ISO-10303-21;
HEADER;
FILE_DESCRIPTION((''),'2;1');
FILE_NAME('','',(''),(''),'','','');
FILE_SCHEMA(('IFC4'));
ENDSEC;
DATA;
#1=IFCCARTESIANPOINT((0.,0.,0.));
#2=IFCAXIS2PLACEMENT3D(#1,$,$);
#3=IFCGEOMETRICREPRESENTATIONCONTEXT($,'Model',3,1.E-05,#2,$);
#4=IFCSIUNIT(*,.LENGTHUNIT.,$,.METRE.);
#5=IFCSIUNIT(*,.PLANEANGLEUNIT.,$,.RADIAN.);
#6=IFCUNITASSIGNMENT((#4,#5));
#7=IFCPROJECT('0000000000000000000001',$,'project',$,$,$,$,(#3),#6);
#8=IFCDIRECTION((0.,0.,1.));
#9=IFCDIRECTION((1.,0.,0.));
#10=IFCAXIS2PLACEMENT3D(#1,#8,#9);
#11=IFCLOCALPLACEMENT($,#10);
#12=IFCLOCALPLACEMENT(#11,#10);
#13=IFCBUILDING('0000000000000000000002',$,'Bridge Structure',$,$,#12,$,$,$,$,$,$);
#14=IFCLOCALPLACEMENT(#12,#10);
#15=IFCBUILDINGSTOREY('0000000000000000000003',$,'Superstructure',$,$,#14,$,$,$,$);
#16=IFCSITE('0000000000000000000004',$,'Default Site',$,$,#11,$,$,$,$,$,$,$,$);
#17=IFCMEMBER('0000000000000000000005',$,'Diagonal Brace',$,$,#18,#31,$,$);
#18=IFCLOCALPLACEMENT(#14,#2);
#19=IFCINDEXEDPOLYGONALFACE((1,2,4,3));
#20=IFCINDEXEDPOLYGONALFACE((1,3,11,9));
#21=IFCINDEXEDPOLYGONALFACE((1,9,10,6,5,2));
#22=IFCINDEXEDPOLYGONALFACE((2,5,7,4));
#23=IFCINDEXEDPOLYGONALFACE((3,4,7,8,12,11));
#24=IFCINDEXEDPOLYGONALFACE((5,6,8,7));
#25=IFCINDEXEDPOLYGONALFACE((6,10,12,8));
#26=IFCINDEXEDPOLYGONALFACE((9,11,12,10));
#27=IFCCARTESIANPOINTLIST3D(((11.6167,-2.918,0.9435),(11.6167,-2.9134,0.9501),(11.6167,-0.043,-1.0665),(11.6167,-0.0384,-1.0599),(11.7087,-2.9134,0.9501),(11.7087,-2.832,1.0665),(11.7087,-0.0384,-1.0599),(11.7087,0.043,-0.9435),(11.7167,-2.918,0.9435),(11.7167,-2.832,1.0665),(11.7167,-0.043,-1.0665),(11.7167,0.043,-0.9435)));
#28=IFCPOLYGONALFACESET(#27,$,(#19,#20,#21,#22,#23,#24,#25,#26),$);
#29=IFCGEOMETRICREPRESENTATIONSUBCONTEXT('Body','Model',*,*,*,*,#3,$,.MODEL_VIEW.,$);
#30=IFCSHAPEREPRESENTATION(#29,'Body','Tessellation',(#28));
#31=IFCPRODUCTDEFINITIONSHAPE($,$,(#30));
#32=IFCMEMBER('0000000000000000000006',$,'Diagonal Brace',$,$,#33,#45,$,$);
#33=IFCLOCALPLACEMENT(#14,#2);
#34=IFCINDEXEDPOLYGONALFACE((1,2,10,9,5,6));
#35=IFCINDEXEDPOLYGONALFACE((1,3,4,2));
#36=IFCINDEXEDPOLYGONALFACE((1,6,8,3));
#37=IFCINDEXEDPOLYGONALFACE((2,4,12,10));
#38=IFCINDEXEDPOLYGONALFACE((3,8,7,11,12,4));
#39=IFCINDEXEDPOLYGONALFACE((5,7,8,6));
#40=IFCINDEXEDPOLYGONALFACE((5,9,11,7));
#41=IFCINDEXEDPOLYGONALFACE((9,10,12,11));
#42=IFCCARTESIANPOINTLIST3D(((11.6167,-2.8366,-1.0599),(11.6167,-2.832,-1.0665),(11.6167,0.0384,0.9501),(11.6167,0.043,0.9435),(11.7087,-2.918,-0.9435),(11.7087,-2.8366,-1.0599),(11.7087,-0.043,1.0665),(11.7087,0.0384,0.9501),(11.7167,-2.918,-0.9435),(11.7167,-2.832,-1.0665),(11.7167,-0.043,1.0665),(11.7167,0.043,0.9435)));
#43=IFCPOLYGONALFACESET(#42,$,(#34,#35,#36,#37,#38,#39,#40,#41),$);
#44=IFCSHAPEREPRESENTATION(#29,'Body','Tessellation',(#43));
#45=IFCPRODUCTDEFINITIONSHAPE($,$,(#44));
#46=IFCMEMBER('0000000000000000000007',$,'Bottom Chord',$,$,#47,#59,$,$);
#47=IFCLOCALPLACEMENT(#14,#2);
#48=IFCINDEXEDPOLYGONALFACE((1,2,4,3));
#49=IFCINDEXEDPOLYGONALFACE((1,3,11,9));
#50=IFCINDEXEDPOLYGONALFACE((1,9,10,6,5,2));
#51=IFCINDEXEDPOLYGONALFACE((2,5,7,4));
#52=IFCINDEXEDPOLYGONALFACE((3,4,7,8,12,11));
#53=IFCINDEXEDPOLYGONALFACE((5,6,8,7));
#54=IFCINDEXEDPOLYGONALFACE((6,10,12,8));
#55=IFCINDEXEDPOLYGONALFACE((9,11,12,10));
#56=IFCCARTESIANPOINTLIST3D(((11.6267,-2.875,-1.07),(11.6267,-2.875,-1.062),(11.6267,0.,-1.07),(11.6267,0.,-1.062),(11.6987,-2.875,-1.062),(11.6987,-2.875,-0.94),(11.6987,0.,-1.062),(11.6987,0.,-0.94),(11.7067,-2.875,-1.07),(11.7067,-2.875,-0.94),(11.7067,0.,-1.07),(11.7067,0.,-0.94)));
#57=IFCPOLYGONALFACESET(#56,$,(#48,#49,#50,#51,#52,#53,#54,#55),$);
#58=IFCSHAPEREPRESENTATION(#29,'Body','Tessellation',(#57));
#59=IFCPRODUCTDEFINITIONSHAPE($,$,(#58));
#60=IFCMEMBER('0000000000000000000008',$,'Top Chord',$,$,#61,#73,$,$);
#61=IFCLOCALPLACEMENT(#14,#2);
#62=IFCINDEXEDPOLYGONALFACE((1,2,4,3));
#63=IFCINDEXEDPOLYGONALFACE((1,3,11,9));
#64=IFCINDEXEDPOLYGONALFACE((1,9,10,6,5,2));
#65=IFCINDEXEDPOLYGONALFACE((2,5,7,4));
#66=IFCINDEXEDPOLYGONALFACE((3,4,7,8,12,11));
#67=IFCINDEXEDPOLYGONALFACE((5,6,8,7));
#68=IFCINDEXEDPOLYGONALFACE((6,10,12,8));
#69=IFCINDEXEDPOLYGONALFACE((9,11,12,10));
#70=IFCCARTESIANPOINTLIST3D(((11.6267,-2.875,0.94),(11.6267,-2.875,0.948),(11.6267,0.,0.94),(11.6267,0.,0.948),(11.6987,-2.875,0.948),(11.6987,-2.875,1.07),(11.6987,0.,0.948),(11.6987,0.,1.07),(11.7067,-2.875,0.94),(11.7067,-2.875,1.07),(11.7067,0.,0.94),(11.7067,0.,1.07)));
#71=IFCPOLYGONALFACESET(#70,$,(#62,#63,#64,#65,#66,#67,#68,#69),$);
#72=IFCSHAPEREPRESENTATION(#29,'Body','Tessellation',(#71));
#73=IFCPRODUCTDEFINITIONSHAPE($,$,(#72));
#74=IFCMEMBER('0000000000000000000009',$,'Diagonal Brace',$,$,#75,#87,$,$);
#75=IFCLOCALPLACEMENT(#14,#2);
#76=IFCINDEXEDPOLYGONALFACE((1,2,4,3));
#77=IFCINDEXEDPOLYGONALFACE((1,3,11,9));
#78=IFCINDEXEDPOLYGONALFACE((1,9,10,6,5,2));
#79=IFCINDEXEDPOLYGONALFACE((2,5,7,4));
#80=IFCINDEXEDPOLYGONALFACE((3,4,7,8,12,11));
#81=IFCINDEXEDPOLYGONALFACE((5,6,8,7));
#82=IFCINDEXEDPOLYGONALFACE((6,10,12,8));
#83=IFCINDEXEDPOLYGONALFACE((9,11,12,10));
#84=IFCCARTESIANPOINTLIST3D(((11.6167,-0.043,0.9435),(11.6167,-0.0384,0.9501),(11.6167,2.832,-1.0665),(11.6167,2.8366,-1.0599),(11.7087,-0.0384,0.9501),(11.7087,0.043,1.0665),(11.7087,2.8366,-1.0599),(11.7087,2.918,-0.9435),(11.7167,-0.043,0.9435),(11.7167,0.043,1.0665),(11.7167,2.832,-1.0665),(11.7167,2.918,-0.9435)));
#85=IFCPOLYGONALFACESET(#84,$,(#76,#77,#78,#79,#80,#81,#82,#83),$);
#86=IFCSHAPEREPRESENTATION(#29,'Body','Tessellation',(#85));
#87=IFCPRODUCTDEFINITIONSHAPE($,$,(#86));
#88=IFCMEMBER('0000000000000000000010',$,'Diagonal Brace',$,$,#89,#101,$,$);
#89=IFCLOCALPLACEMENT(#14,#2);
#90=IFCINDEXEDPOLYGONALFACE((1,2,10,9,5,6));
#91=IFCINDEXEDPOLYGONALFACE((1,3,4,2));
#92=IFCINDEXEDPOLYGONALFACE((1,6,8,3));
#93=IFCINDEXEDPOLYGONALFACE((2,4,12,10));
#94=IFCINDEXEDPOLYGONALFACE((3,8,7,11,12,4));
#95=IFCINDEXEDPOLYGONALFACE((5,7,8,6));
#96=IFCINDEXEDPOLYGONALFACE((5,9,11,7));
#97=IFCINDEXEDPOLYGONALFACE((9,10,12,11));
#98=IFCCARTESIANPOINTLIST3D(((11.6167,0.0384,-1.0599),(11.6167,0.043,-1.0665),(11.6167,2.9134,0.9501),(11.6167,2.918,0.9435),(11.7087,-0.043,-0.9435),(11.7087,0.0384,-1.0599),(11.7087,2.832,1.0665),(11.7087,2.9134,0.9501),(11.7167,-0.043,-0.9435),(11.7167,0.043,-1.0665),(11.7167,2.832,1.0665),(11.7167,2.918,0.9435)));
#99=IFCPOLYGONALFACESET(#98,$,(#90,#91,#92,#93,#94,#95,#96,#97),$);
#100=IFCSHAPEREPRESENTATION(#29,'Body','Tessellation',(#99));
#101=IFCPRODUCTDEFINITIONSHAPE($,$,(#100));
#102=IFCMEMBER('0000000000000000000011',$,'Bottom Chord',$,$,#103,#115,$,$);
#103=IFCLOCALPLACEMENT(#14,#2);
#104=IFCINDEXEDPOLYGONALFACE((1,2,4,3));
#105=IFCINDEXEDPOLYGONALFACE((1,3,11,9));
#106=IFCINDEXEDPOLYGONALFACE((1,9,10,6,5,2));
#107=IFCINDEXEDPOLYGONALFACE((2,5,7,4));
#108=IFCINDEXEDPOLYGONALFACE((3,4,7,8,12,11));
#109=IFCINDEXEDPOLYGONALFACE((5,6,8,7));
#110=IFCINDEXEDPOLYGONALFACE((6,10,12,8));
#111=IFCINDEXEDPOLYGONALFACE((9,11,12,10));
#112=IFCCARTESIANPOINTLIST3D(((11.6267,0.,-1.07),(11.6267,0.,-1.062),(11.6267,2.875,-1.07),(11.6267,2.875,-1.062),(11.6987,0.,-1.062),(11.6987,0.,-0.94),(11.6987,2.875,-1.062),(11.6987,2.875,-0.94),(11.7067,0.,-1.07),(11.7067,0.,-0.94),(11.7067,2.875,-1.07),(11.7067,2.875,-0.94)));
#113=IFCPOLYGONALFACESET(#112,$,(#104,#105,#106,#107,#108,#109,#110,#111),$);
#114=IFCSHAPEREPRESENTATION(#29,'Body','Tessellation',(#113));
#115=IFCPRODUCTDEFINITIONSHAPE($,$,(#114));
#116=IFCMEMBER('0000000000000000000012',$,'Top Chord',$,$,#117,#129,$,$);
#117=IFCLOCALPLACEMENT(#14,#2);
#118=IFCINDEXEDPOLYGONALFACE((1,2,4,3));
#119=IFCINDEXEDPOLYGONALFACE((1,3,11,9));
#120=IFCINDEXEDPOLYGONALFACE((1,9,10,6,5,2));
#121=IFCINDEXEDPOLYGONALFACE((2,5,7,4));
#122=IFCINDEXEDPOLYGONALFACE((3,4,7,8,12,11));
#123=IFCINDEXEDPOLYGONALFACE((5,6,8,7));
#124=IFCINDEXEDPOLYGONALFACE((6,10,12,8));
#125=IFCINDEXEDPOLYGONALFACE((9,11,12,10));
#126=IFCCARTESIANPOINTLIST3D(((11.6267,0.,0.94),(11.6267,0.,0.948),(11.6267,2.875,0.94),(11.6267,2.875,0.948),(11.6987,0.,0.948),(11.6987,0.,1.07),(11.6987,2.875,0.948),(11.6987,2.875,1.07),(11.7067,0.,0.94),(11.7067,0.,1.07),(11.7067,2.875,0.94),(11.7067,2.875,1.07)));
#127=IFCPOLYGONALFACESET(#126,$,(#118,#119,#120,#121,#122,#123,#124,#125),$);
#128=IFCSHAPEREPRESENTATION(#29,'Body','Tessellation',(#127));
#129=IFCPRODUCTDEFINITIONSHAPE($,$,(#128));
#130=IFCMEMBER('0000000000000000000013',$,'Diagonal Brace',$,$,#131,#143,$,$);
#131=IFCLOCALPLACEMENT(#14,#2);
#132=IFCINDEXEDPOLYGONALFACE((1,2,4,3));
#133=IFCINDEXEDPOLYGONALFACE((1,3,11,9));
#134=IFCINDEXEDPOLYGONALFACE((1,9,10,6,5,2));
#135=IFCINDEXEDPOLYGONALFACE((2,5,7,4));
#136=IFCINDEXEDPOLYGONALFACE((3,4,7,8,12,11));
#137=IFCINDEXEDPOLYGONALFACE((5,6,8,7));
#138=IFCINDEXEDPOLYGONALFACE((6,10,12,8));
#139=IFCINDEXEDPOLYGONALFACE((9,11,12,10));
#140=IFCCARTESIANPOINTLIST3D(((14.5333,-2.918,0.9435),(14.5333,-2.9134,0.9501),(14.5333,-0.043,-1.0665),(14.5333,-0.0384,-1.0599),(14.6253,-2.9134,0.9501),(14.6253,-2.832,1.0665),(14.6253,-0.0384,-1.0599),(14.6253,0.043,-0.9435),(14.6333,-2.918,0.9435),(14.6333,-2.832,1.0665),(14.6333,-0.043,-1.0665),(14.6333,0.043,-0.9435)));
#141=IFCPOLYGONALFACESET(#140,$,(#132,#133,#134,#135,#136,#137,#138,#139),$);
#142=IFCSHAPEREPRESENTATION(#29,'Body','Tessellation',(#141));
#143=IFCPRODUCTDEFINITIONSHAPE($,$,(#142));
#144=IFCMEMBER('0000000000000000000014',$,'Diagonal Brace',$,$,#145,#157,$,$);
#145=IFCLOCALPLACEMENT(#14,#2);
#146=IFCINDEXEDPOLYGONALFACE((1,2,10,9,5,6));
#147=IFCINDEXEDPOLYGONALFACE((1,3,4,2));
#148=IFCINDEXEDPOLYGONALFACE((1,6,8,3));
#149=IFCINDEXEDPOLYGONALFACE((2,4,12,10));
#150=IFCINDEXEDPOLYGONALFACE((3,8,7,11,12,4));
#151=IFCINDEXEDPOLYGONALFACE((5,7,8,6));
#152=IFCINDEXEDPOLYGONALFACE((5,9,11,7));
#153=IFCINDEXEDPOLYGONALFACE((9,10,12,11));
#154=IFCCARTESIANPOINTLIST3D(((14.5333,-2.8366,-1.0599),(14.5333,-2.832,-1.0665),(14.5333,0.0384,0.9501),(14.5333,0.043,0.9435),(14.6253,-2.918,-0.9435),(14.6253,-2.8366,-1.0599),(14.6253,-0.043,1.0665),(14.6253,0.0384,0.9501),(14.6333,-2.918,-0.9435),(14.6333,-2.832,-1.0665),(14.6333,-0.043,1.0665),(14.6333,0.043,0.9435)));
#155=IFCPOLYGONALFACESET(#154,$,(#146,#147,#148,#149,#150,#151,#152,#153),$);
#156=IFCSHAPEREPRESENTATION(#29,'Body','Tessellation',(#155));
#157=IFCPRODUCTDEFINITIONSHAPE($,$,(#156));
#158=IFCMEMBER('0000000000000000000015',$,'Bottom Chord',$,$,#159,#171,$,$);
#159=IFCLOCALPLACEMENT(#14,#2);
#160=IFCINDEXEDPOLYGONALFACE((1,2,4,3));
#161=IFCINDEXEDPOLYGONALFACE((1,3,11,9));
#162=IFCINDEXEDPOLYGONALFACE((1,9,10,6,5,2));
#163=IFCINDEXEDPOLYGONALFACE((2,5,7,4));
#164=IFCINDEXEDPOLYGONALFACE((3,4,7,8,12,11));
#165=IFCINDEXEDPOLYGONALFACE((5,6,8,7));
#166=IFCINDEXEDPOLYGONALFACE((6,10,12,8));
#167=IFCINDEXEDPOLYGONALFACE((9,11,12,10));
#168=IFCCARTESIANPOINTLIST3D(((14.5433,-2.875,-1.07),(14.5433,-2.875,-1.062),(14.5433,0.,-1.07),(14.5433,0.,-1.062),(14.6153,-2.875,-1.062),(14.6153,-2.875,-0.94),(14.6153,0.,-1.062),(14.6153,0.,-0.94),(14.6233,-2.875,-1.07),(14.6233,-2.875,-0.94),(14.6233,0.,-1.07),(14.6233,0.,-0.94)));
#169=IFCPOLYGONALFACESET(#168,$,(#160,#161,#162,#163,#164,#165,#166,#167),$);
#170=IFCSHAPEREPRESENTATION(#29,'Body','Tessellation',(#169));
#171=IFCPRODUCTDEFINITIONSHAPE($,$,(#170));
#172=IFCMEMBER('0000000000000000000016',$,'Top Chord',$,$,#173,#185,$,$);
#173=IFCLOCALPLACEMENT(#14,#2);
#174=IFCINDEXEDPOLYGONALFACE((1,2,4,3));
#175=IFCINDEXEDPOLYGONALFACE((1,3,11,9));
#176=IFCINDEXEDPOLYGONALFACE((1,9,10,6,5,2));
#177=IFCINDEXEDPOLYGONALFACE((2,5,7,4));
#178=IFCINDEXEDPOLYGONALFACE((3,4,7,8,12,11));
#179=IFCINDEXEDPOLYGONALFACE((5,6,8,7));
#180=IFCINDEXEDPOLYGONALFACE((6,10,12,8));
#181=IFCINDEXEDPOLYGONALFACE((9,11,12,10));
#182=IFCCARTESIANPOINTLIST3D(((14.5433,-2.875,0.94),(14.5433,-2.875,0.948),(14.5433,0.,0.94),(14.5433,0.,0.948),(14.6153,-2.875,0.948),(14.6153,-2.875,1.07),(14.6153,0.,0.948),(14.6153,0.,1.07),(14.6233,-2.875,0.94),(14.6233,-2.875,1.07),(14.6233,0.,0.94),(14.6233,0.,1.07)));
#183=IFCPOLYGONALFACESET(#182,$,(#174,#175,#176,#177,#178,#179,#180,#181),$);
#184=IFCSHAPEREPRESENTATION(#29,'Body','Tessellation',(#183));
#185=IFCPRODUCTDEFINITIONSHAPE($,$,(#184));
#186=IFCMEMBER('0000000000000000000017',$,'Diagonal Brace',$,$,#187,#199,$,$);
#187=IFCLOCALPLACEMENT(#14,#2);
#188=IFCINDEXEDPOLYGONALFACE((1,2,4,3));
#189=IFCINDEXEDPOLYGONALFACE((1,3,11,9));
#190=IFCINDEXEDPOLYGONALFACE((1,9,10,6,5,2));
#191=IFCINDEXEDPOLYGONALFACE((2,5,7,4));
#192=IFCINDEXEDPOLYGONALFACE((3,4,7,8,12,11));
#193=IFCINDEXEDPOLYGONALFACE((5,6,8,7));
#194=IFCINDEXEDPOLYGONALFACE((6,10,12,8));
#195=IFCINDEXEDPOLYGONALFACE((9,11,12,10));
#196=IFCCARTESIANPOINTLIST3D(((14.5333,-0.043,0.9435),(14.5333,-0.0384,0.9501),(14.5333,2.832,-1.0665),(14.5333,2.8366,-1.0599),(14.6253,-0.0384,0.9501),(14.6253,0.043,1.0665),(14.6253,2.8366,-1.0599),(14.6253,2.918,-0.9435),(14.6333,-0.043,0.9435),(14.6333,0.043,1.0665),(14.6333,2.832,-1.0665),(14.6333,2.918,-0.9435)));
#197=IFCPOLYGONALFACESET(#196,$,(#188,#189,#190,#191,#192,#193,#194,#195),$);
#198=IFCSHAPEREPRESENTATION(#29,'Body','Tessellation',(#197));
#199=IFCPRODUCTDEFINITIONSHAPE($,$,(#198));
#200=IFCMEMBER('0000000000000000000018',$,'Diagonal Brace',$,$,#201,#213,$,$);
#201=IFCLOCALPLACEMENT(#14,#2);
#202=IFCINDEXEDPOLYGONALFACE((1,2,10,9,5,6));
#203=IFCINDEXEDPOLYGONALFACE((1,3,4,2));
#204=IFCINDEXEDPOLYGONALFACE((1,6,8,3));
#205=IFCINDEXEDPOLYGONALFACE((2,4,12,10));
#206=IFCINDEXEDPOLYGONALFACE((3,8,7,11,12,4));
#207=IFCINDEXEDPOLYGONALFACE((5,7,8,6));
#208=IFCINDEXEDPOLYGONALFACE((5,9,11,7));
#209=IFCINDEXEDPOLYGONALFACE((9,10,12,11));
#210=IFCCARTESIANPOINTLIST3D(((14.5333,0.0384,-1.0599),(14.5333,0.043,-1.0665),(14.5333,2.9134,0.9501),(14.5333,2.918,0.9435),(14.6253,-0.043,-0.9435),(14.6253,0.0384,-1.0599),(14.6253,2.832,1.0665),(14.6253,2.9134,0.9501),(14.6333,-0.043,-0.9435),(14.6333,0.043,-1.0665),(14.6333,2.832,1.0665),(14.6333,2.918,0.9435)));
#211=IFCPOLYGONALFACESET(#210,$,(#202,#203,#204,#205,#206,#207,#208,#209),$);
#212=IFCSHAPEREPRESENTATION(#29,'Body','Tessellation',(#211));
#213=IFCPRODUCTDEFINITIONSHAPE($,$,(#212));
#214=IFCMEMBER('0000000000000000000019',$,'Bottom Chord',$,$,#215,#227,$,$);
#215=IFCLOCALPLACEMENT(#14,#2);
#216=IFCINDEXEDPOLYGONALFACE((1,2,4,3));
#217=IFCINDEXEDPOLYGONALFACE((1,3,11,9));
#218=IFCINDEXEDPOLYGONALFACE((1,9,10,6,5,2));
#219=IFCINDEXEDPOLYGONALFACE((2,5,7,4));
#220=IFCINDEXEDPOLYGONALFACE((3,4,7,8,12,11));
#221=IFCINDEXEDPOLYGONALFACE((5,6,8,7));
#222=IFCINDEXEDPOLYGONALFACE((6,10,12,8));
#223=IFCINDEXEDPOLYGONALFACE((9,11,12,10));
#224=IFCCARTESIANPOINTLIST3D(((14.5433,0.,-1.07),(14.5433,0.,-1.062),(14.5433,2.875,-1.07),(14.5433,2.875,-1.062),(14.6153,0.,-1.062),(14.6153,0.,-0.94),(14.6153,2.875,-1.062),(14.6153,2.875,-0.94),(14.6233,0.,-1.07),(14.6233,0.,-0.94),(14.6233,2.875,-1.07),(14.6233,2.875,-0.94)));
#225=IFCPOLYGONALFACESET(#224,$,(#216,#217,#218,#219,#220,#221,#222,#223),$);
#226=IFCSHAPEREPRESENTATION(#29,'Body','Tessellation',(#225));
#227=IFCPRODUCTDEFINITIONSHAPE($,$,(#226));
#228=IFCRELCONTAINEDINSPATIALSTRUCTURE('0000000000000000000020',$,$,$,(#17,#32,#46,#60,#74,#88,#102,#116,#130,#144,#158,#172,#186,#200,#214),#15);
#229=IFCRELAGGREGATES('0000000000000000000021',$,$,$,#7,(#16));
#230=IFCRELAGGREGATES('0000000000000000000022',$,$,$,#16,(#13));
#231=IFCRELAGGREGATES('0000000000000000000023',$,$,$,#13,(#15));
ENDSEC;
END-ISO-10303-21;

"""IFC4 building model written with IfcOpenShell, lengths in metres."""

from ifc_helpers import new_model, si_unit, frame, origin, origin_with_axes, origin_2d_with_axis, place, context, subcontext, project, spatial, l_section, extrude, element, save


model = new_model("IFC4")

# Units and contexts
model_context = context("Model", 3, precision=1e-05, world=origin())
body_context = subcontext(model_context, "Body", "Model", "MODEL_VIEW")
ifc_project = project(units=[si_unit("LENGTHUNIT", "METRE"), si_unit("PLANEANGLEUNIT", "RADIAN")], contexts=[model_context])

# Site, building, storey
site_placement = place(None, origin_with_axes())
site = spatial("IfcSite", under=ifc_project, at=site_placement, Name="Default Site")
building_placement = place(site_placement, origin_with_axes())
building = spatial("IfcBuilding", under=site, at=building_placement, Name="Bridge Structure")
storey_placement = place(building_placement, origin_with_axes())
storey = spatial("IfcBuildingStorey", under=building, at=storey_placement, Name="Superstructure")

# Members
for number, where, z_axis, x_axis, name in (
    (1, (11.6667, -2.875, 1.005), (0.0, 0.819567, -0.572984), (-1.0, 0.0, 0.0), "Diagonal Brace"),
    (2, (11.6667, -2.875, -1.005), (0.0, 0.819567, 0.572984), (-1.0, 0.0, 0.0), "Diagonal Brace"),
):
    element("IfcMember", number, at=place(storey_placement, frame(where, z_axis=z_axis, x_axis=x_axis)), inside=storey, Name=name, context=body_context, shape_type="SweptSolid", body=[
        extrude(l_section(Depth=0.15, Width=0.1, Thickness=0.008, at=origin_2d_with_axis()), origin_with_axes(), (0.0, 0.0, 1.0), 3.508),
    ])
for number, where, z_axis, x_axis, name in (
    (3, (11.6667, -2.875, -1.005), (0.0, 1.0, 0.0), (-1.0, 0.0, 0.0), "Bottom Chord"),
    (4, (11.6667, -2.875, 1.005), (0.0, 1.0, 0.0), (-1.0, 0.0, 0.0), "Top Chord"),
):
    element("IfcMember", number, at=place(storey_placement, frame(where, z_axis=z_axis, x_axis=x_axis)), inside=storey, Name=name, context=body_context, shape_type="SweptSolid", body=[
        extrude(l_section(Depth=0.13, Width=0.08, Thickness=0.008, at=origin_2d_with_axis()), origin_with_axes(), (0.0, 0.0, 1.0), 2.875),
    ])
for number, where, z_axis, x_axis, name in (
    (5, (11.6667, 0.0, 1.005), (0.0, 0.819567, -0.572984), (-1.0, 0.0, 0.0), "Diagonal Brace"),
    (6, (11.6667, 0.0, -1.005), (0.0, 0.819567, 0.572984), (-1.0, 0.0, 0.0), "Diagonal Brace"),
):
    element("IfcMember", number, at=place(storey_placement, frame(where, z_axis=z_axis, x_axis=x_axis)), inside=storey, Name=name, context=body_context, shape_type="SweptSolid", body=[
        extrude(l_section(Depth=0.15, Width=0.1, Thickness=0.008, at=origin_2d_with_axis()), origin_with_axes(), (0.0, 0.0, 1.0), 3.508),
    ])
for number, where, z_axis, x_axis, name in (
    (7, (11.6667, 0.0, -1.005), (0.0, 1.0, 0.0), (-1.0, 0.0, 0.0), "Bottom Chord"),
    (8, (11.6667, 0.0, 1.005), (0.0, 1.0, 0.0), (-1.0, 0.0, 0.0), "Top Chord"),
):
    element("IfcMember", number, at=place(storey_placement, frame(where, z_axis=z_axis, x_axis=x_axis)), inside=storey, Name=name, context=body_context, shape_type="SweptSolid", body=[
        extrude(l_section(Depth=0.13, Width=0.08, Thickness=0.008, at=origin_2d_with_axis()), origin_with_axes(), (0.0, 0.0, 1.0), 2.875),
    ])
for number, where, z_axis, x_axis, name in (
    (9, (14.5833, -2.875, 1.005), (0.0, 0.819567, -0.572984), (-1.0, 0.0, 0.0), "Diagonal Brace"),
    (10, (14.5833, -2.875, -1.005), (0.0, 0.819567, 0.572984), (-1.0, 0.0, 0.0), "Diagonal Brace"),
):
    element("IfcMember", number, at=place(storey_placement, frame(where, z_axis=z_axis, x_axis=x_axis)), inside=storey, Name=name, context=body_context, shape_type="SweptSolid", body=[
        extrude(l_section(Depth=0.15, Width=0.1, Thickness=0.008, at=origin_2d_with_axis()), origin_with_axes(), (0.0, 0.0, 1.0), 3.508),
    ])
for number, where, z_axis, x_axis, name in (
    (11, (14.5833, -2.875, -1.005), (0.0, 1.0, 0.0), (-1.0, 0.0, 0.0), "Bottom Chord"),
    (12, (14.5833, -2.875, 1.005), (0.0, 1.0, 0.0), (-1.0, 0.0, 0.0), "Top Chord"),
):
    element("IfcMember", number, at=place(storey_placement, frame(where, z_axis=z_axis, x_axis=x_axis)), inside=storey, Name=name, context=body_context, shape_type="SweptSolid", body=[
        extrude(l_section(Depth=0.13, Width=0.08, Thickness=0.008, at=origin_2d_with_axis()), origin_with_axes(), (0.0, 0.0, 1.0), 2.875),
    ])
for number, where, z_axis, x_axis, name in (
    (13, (14.5833, 0.0, 1.005), (0.0, 0.819567, -0.572984), (-1.0, 0.0, 0.0), "Diagonal Brace"),
    (14, (14.5833, 0.0, -1.005), (0.0, 0.819567, 0.572984), (-1.0, 0.0, 0.0), "Diagonal Brace"),
):
    element("IfcMember", number, at=place(storey_placement, frame(where, z_axis=z_axis, x_axis=x_axis)), inside=storey, Name=name, context=body_context, shape_type="SweptSolid", body=[
        extrude(l_section(Depth=0.15, Width=0.1, Thickness=0.008, at=origin_2d_with_axis()), origin_with_axes(), (0.0, 0.0, 1.0), 3.508),
    ])
for number, where, z_axis, x_axis, name in (
    (15, (14.5833, 0.0, -1.005), (0.0, 1.0, 0.0), (-1.0, 0.0, 0.0), "Bottom Chord"),
):
    element("IfcMember", number, at=place(storey_placement, frame(where, z_axis=z_axis, x_axis=x_axis)), inside=storey, Name=name, context=body_context, shape_type="SweptSolid", body=[
        extrude(l_section(Depth=0.13, Width=0.08, Thickness=0.008, at=origin_2d_with_axis()), origin_with_axes(), (0.0, 0.0, 1.0), 2.875),
    ])

save(model, "model.ifc")
